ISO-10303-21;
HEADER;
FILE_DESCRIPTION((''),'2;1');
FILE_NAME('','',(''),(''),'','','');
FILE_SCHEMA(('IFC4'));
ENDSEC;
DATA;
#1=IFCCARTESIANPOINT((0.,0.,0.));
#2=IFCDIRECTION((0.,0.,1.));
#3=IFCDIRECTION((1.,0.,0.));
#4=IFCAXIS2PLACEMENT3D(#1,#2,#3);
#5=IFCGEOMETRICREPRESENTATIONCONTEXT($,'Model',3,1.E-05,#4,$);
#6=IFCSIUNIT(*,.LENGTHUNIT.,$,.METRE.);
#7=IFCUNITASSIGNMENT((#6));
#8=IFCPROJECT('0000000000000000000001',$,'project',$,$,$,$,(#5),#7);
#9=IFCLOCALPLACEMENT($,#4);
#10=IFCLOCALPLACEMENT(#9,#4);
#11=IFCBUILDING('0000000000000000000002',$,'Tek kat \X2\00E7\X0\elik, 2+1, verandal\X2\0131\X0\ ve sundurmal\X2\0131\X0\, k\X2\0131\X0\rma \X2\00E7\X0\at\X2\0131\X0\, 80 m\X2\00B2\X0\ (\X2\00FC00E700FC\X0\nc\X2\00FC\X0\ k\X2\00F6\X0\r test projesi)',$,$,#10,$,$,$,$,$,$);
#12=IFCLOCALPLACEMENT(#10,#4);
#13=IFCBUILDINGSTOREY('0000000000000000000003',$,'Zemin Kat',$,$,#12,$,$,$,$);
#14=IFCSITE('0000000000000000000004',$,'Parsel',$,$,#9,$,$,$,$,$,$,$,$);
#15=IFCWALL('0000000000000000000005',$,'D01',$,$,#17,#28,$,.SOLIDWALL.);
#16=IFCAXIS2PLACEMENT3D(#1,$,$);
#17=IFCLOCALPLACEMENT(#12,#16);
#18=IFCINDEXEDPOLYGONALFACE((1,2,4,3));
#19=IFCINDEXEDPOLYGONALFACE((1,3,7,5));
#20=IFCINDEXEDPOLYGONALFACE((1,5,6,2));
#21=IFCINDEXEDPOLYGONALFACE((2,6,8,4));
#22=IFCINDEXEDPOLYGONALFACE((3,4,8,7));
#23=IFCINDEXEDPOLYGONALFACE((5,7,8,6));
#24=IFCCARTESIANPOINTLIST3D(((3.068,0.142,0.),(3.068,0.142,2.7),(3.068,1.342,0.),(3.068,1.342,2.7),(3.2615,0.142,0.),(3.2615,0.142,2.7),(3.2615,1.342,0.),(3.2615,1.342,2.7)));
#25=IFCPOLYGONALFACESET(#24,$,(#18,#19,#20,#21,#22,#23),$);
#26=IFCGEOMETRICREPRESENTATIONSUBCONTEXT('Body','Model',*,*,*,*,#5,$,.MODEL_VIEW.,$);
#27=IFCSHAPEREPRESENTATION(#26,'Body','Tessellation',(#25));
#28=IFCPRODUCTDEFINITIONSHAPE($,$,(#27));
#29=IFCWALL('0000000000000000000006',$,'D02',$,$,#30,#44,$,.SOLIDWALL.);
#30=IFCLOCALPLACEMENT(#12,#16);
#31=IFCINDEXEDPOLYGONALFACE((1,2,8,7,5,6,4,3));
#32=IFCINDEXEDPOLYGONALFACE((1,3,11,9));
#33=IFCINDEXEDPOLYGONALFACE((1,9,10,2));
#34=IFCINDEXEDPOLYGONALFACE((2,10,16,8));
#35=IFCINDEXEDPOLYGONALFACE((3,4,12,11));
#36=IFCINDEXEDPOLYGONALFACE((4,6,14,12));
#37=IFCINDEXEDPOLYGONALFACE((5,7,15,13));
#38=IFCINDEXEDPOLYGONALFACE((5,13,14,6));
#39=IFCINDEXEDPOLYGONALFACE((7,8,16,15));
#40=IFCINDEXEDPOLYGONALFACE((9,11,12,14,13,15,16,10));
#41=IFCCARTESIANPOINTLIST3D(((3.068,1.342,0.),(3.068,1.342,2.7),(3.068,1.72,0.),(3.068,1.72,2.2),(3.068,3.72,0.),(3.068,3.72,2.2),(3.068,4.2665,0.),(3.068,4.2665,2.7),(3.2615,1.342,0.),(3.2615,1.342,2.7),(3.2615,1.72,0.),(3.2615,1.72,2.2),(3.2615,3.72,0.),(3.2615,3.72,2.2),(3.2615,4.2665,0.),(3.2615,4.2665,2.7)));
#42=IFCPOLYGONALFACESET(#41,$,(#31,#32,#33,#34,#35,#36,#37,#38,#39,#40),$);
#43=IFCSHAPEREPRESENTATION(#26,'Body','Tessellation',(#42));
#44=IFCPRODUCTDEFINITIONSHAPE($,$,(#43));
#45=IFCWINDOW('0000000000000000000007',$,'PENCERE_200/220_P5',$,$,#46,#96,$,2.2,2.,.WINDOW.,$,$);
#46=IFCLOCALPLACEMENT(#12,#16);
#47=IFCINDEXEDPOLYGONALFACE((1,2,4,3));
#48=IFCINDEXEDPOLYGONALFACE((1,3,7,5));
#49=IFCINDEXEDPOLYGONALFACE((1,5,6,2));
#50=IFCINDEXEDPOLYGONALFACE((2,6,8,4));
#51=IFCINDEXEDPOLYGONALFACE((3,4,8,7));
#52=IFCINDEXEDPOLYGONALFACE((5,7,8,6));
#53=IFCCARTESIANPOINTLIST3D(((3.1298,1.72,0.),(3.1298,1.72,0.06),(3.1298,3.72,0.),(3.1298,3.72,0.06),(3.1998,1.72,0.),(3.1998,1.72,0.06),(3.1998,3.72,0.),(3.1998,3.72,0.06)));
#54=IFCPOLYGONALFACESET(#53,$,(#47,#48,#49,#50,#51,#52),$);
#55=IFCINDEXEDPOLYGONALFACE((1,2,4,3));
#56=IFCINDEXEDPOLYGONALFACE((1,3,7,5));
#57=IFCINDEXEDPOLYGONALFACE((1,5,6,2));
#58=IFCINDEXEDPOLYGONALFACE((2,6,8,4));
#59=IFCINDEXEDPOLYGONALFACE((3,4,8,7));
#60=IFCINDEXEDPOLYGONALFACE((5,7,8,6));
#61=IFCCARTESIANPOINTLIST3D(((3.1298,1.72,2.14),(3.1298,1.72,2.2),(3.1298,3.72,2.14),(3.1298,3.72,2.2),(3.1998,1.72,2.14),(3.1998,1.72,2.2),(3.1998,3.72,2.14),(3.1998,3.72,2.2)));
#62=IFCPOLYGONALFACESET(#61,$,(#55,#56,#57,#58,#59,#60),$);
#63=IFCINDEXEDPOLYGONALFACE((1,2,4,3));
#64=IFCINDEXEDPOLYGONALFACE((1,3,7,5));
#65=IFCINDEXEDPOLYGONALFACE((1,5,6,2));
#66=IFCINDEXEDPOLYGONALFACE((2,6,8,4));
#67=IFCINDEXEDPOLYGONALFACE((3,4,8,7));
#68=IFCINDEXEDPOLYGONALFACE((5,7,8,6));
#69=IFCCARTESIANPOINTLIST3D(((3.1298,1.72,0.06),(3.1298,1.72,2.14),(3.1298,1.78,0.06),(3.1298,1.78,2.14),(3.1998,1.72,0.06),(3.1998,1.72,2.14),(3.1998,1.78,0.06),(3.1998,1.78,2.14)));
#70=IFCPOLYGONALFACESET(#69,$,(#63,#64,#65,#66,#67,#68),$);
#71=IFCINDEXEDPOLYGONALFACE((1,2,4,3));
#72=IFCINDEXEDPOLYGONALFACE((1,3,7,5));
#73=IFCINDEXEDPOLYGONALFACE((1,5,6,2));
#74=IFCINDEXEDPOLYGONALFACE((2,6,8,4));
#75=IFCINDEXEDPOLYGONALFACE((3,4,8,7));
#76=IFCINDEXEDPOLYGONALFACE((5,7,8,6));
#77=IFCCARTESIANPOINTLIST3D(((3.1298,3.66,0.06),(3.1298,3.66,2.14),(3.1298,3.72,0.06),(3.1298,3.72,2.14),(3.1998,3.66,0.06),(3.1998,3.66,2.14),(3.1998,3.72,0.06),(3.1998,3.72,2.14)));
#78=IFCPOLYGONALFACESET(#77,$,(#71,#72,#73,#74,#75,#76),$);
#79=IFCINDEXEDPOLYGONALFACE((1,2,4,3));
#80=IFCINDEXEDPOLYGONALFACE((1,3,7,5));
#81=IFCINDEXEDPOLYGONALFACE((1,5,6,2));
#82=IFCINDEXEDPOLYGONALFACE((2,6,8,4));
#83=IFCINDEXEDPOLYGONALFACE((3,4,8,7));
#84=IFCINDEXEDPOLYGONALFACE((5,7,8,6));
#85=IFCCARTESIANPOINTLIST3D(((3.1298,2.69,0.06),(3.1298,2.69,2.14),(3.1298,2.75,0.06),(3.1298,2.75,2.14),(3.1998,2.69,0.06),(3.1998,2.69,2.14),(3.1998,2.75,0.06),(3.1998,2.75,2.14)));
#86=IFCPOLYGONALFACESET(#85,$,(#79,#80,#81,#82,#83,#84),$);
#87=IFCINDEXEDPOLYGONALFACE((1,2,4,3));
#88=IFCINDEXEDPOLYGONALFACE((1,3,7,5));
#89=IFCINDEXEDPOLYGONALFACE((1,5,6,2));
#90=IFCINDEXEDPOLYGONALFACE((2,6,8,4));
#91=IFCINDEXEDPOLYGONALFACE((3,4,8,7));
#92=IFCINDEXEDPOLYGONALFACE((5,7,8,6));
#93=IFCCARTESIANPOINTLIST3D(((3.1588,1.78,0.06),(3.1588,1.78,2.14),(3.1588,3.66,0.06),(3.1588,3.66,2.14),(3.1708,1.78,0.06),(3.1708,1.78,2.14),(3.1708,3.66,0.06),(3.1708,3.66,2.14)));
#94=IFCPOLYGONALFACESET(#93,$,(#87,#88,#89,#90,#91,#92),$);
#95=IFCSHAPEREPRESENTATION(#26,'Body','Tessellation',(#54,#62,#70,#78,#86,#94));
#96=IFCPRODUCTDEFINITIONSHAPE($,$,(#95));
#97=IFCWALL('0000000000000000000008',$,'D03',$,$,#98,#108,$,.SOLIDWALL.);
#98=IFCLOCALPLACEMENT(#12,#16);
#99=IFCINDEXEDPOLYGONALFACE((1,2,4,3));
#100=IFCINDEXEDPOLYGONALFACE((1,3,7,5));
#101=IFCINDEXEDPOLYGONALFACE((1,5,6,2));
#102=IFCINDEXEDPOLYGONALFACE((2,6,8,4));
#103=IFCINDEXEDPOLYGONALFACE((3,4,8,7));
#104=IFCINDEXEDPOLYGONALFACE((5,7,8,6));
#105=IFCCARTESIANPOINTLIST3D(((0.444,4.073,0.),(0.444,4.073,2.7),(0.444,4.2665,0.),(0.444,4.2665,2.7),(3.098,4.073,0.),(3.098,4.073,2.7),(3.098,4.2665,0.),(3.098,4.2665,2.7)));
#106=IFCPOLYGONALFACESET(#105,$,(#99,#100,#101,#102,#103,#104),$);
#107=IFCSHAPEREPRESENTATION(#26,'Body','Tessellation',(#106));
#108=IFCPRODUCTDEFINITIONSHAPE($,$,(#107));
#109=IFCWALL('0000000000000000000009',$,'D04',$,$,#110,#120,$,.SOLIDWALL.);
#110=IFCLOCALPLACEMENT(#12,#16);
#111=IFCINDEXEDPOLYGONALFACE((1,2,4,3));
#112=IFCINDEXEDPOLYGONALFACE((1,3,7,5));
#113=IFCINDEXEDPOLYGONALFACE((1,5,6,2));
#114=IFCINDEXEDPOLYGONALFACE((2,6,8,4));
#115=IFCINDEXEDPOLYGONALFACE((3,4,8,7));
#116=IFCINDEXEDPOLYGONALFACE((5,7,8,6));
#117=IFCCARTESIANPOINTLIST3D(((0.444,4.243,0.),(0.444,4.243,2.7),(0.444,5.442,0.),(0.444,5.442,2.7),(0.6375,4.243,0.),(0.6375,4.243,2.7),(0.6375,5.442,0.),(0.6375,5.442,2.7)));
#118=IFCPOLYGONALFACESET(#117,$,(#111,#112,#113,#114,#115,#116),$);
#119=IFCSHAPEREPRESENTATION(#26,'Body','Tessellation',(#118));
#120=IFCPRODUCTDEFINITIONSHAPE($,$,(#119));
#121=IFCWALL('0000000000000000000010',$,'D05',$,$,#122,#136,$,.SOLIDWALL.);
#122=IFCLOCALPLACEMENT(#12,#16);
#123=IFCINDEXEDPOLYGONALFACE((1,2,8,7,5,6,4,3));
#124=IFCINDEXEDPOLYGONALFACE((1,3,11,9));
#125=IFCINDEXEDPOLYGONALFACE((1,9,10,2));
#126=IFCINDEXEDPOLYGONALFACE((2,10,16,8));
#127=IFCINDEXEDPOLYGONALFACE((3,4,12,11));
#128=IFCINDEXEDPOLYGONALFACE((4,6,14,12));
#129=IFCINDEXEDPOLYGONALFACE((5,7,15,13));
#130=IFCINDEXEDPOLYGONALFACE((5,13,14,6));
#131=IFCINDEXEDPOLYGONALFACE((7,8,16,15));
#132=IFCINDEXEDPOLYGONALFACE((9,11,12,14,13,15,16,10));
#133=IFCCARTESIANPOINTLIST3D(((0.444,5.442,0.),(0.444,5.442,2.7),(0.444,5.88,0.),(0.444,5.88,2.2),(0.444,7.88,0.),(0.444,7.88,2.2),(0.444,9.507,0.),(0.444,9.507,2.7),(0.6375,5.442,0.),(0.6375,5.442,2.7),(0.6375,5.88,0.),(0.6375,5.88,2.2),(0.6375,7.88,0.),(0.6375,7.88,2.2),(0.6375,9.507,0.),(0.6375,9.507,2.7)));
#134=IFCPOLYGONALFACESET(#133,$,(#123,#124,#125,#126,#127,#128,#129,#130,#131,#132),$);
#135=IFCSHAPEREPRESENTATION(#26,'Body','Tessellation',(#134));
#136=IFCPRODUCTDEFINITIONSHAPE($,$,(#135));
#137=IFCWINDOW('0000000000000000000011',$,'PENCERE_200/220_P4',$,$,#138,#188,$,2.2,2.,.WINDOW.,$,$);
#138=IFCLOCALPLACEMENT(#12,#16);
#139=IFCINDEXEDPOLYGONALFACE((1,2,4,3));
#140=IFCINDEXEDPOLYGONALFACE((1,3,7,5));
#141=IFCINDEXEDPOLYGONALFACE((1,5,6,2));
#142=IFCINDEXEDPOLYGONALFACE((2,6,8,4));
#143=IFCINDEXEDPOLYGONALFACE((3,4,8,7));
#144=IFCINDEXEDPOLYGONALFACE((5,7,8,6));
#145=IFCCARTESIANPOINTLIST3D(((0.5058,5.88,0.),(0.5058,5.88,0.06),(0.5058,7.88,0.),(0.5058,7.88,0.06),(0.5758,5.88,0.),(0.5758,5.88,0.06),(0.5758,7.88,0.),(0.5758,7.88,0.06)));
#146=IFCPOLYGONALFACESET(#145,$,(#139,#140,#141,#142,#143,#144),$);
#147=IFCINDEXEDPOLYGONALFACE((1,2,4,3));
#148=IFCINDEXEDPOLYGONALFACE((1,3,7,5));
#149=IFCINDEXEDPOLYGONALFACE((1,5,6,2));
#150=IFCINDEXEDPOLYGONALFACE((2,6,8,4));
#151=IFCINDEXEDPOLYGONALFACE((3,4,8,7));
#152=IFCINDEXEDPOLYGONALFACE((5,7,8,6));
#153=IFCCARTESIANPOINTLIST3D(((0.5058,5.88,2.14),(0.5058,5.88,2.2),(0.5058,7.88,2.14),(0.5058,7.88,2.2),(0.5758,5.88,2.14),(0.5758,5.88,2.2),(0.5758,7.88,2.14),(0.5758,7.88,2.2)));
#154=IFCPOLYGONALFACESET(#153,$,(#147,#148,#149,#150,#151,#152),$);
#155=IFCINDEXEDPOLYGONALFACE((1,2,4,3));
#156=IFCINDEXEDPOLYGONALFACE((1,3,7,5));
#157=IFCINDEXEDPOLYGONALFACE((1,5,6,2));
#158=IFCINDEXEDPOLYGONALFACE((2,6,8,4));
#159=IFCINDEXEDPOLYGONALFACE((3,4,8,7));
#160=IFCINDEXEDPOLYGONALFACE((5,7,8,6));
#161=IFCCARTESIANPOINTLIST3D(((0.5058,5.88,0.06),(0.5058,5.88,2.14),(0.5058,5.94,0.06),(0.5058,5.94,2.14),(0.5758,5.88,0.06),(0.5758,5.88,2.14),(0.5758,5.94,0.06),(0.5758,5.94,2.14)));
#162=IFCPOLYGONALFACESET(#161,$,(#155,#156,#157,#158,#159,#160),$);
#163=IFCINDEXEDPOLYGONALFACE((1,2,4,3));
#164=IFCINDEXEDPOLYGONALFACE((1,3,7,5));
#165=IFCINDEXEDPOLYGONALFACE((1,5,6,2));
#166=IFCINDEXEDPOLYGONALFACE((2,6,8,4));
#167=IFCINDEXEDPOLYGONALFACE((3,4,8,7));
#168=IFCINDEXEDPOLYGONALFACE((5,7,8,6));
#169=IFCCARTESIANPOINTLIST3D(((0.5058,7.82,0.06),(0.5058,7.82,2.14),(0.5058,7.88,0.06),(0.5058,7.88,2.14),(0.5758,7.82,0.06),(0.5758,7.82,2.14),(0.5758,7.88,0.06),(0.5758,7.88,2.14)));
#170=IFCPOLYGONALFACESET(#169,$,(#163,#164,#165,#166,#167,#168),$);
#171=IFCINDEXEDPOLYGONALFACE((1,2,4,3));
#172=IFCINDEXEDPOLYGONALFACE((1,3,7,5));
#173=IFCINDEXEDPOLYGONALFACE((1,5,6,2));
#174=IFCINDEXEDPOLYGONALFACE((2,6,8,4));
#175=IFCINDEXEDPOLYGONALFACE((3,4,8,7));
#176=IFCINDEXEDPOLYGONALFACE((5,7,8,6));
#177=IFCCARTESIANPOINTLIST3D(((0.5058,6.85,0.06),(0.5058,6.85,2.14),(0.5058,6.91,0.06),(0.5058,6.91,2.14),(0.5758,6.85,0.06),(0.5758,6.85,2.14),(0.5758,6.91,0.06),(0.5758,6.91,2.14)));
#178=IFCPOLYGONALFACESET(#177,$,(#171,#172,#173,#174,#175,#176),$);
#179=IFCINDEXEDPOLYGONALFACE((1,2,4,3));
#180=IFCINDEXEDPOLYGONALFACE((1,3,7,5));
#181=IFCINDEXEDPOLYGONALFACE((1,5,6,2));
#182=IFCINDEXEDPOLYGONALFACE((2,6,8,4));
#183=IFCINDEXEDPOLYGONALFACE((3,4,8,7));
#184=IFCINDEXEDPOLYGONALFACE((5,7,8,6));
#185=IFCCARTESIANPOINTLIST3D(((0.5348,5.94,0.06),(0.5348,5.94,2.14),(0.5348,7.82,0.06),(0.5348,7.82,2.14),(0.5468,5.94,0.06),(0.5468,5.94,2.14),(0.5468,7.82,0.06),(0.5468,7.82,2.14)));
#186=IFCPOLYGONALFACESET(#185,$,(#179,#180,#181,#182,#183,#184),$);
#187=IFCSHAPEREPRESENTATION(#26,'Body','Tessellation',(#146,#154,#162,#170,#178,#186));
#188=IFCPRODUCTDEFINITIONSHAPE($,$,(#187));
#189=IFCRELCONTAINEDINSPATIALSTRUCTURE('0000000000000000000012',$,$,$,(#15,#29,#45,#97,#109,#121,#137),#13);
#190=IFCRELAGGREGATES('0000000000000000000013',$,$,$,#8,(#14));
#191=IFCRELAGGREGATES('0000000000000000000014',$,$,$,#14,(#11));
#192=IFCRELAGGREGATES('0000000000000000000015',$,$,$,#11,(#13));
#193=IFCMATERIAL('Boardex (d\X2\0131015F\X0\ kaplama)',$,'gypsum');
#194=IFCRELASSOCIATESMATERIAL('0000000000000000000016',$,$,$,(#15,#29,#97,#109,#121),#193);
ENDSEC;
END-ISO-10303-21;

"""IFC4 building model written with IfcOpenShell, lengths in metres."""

from ifc_helpers import new_model, si_unit, frame, origin_with_axes, place, context, subcontext, project, spatial, line, indexed_curve, outline, extrude, material, element, fill, save


model = new_model("IFC4")

# Units and contexts
model_context = context("Model", 3, precision=1e-05, world=origin_with_axes())
body_context = subcontext(model_context, "Body", "Model", "MODEL_VIEW")
ifc_project = project(units=[si_unit("LENGTHUNIT", "METRE")], contexts=[model_context])

# Site, building, storey
site_placement = place(None, origin_with_axes())
site = spatial("IfcSite", under=ifc_project, at=site_placement, Name="Parsel")
building_placement = place(site_placement, origin_with_axes())
building = spatial("IfcBuilding", under=site, at=building_placement, Name="Tek kat çelik, 2+1, verandalı ve sundurmalı, kırma çatı, 80 m² (üçüncü kör test projesi)")
storey_placement = place(building_placement, origin_with_axes())
storey = spatial("IfcBuildingStorey", under=building, at=storey_placement, Name="Zemin Kat")

# Wall
ifc_material_1 = material(Name="Boardex (dış kaplama)", Category="gypsum")
wall_1_placement = place(storey_placement, origin_with_axes())
element("IfcWall", 1, at=wall_1_placement, inside=storey, material=ifc_material_1, Name="D01", PredefinedType="SOLIDWALL", context=body_context, shape_type="SweptSolid", body=[
    extrude(outline(indexed_curve([(0.0, 0.0), (0.1935, 0.0), (0.1935, 1.2), (0.0, 1.2)], segments=[line(1, 2, 3, 4, 1)])), frame((3.068, 0.142, 0.0), z_axis=(0.0, 0.0, 1.0), x_axis=(1.0, 0.0, 0.0)), (0.0, 0.0, 1.0), 2.7),
])

# Wall, opening, window
wall_2_placement = place(storey_placement, origin_with_axes())
wall_2 = element("IfcWall", 2, at=wall_2_placement, inside=storey, material=ifc_material_1, Name="D02", PredefinedType="SOLIDWALL", context=body_context, shape_type="SweptSolid", body=[
    extrude(outline(indexed_curve([(0.0, 0.0), (0.1935, 0.0), (0.1935, 2.9245), (0.0, 2.9245)], segments=[line(1, 2, 3, 4, 1)])), frame((3.068, 1.342, 0.0), z_axis=(0.0, 0.0, 1.0), x_axis=(1.0, 0.0, 0.0)), (0.0, 0.0, 1.0), 2.7),
])
opening_1_placement = place(wall_2_placement, origin_with_axes())
opening_1 = element("IfcOpeningElement", 3, at=opening_1_placement, cuts=wall_2, PredefinedType="OPENING", context=body_context, shape_type="SweptSolid", body=[
    extrude(outline(indexed_curve([(0.0, 0.0), (0.2335, 0.0), (0.2335, 2.0), (0.0, 2.0)], segments=[line(1, 2, 3, 4, 1)])), frame((3.048, 1.72, 0.0), z_axis=(0.0, 0.0, 1.0), x_axis=(1.0, 0.0, 0.0)), (0.0, 0.0, 1.0), 2.2),
])
window_1_placement = place(storey_placement, origin_with_axes())
window_1 = element("IfcWindow", 4, at=window_1_placement, inside=storey, Name="PENCERE_200/220_P5", OverallHeight=2.2, OverallWidth=2.0, PredefinedType="WINDOW", context=body_context, shape_type="SweptSolid", body=[
    extrude(outline(indexed_curve([(0.0, 0.0), (0.07, 0.0), (0.07, 2.0), (0.0, 2.0)], segments=[line(1, 2, 3, 4, 1)])), frame((3.1298, 1.72, 0.0), z_axis=(0.0, 0.0, 1.0), x_axis=(1.0, 0.0, 0.0)), (0.0, 0.0, 1.0), 0.06),
    extrude(outline(indexed_curve([(0.0, 0.0), (0.07, 0.0), (0.07, 2.0), (0.0, 2.0)], segments=[line(1, 2, 3, 4, 1)])), frame((3.1298, 1.72, 2.14), z_axis=(0.0, 0.0, 1.0), x_axis=(1.0, 0.0, 0.0)), (0.0, 0.0, 1.0), 0.06),
    extrude(outline(indexed_curve([(0.0, 0.0), (0.07, 0.0), (0.07, 0.06), (0.0, 0.06)], segments=[line(1, 2, 3, 4, 1)])), frame((3.1298, 1.72, 0.06), z_axis=(0.0, 0.0, 1.0), x_axis=(1.0, 0.0, 0.0)), (0.0, 0.0, 1.0), 2.08),
    extrude(outline(indexed_curve([(0.0, 0.0), (0.07, 0.0), (0.07, 0.06), (0.0, 0.06)], segments=[line(1, 2, 3, 4, 1)])), frame((3.1298, 3.66, 0.06), z_axis=(0.0, 0.0, 1.0), x_axis=(1.0, 0.0, 0.0)), (0.0, 0.0, 1.0), 2.08),
    extrude(outline(indexed_curve([(0.0, 0.0), (0.07, 0.0), (0.07, 0.06), (0.0, 0.06)], segments=[line(1, 2, 3, 4, 1)])), frame((3.1298, 2.69, 0.06), z_axis=(0.0, 0.0, 1.0), x_axis=(1.0, 0.0, 0.0)), (0.0, 0.0, 1.0), 2.08),
    extrude(outline(indexed_curve([(0.0, 0.0), (0.012, 0.0), (0.012, 1.88), (0.0, 1.88)], segments=[line(1, 2, 3, 4, 1)])), frame((3.1587, 1.78, 0.06), z_axis=(0.0, 0.0, 1.0), x_axis=(1.0, 0.0, 0.0)), (0.0, 0.0, 1.0), 2.08),
])
fill(opening_1, window_1)

# Walls
wall_3_placement = place(storey_placement, origin_with_axes())
element("IfcWall", 5, at=wall_3_placement, inside=storey, material=ifc_material_1, Name="D03", PredefinedType="SOLIDWALL", context=body_context, shape_type="SweptSolid", body=[
    extrude(outline(indexed_curve([(0.0, 0.0), (2.654, 0.0), (2.654, 0.1935), (0.0, 0.1935)], segments=[line(1, 2, 3, 4, 1)])), frame((0.444, 4.073, 0.0), z_axis=(0.0, 0.0, 1.0), x_axis=(1.0, 0.0, 0.0)), (0.0, 0.0, 1.0), 2.7),
])
wall_4_placement = place(storey_placement, origin_with_axes())
element("IfcWall", 6, at=wall_4_placement, inside=storey, material=ifc_material_1, Name="D04", PredefinedType="SOLIDWALL", context=body_context, shape_type="SweptSolid", body=[
    extrude(outline(indexed_curve([(0.0, 0.0), (0.1935, 0.0), (0.1935, 1.199), (0.0, 1.199)], segments=[line(1, 2, 3, 4, 1)])), frame((0.444, 4.243, 0.0), z_axis=(0.0, 0.0, 1.0), x_axis=(1.0, 0.0, 0.0)), (0.0, 0.0, 1.0), 2.7),
])

# Wall, opening, window
wall_5_placement = place(storey_placement, origin_with_axes())
wall_5 = element("IfcWall", 7, at=wall_5_placement, inside=storey, material=ifc_material_1, Name="D05", PredefinedType="SOLIDWALL", context=body_context, shape_type="SweptSolid", body=[
    extrude(outline(indexed_curve([(0.0, 0.0), (0.1935, 0.0), (0.1935, 4.065), (0.0, 4.065)], segments=[line(1, 2, 3, 4, 1)])), frame((0.444, 5.442, 0.0), z_axis=(0.0, 0.0, 1.0), x_axis=(1.0, 0.0, 0.0)), (0.0, 0.0, 1.0), 2.7),
])
opening_2_placement = place(wall_5_placement, origin_with_axes())
opening_2 = element("IfcOpeningElement", 8, at=opening_2_placement, cuts=wall_5, PredefinedType="OPENING", context=body_context, shape_type="SweptSolid", body=[
    extrude(outline(indexed_curve([(0.0, 0.0), (0.2335, 0.0), (0.2335, 2.0), (0.0, 2.0)], segments=[line(1, 2, 3, 4, 1)])), frame((0.424, 5.88, 0.0), z_axis=(0.0, 0.0, 1.0), x_axis=(1.0, 0.0, 0.0)), (0.0, 0.0, 1.0), 2.2),
])
window_2_placement = place(storey_placement, origin_with_axes())
window_2 = element("IfcWindow", 9, at=window_2_placement, inside=storey, Name="PENCERE_200/220_P4", OverallHeight=2.2, OverallWidth=2.0, PredefinedType="WINDOW", context=body_context, shape_type="SweptSolid", body=[
    extrude(outline(indexed_curve([(0.0, 0.0), (0.07, 0.0), (0.07, 2.0), (0.0, 2.0)], segments=[line(1, 2, 3, 4, 1)])), frame((0.5058, 5.88, 0.0), z_axis=(0.0, 0.0, 1.0), x_axis=(1.0, 0.0, 0.0)), (0.0, 0.0, 1.0), 0.06),
    extrude(outline(indexed_curve([(0.0, 0.0), (0.07, 0.0), (0.07, 2.0), (0.0, 2.0)], segments=[line(1, 2, 3, 4, 1)])), frame((0.5058, 5.88, 2.14), z_axis=(0.0, 0.0, 1.0), x_axis=(1.0, 0.0, 0.0)), (0.0, 0.0, 1.0), 0.06),
    extrude(outline(indexed_curve([(0.0, 0.0), (0.07, 0.0), (0.07, 0.06), (0.0, 0.06)], segments=[line(1, 2, 3, 4, 1)])), frame((0.5058, 5.88, 0.06), z_axis=(0.0, 0.0, 1.0), x_axis=(1.0, 0.0, 0.0)), (0.0, 0.0, 1.0), 2.08),
    extrude(outline(indexed_curve([(0.0, 0.0), (0.07, 0.0), (0.07, 0.06), (0.0, 0.06)], segments=[line(1, 2, 3, 4, 1)])), frame((0.5058, 7.82, 0.06), z_axis=(0.0, 0.0, 1.0), x_axis=(1.0, 0.0, 0.0)), (0.0, 0.0, 1.0), 2.08),
    extrude(outline(indexed_curve([(0.0, 0.0), (0.07, 0.0), (0.07, 0.06), (0.0, 0.06)], segments=[line(1, 2, 3, 4, 1)])), frame((0.5058, 6.85, 0.06), z_axis=(0.0, 0.0, 1.0), x_axis=(1.0, 0.0, 0.0)), (0.0, 0.0, 1.0), 2.08),
    extrude(outline(indexed_curve([(0.0, 0.0), (0.012, 0.0), (0.012, 1.88), (0.0, 1.88)], segments=[line(1, 2, 3, 4, 1)])), frame((0.5348, 5.94, 0.06), z_axis=(0.0, 0.0, 1.0), x_axis=(1.0, 0.0, 0.0)), (0.0, 0.0, 1.0), 2.08),
])
fill(opening_2, window_2)

save(model, "model.ifc")
